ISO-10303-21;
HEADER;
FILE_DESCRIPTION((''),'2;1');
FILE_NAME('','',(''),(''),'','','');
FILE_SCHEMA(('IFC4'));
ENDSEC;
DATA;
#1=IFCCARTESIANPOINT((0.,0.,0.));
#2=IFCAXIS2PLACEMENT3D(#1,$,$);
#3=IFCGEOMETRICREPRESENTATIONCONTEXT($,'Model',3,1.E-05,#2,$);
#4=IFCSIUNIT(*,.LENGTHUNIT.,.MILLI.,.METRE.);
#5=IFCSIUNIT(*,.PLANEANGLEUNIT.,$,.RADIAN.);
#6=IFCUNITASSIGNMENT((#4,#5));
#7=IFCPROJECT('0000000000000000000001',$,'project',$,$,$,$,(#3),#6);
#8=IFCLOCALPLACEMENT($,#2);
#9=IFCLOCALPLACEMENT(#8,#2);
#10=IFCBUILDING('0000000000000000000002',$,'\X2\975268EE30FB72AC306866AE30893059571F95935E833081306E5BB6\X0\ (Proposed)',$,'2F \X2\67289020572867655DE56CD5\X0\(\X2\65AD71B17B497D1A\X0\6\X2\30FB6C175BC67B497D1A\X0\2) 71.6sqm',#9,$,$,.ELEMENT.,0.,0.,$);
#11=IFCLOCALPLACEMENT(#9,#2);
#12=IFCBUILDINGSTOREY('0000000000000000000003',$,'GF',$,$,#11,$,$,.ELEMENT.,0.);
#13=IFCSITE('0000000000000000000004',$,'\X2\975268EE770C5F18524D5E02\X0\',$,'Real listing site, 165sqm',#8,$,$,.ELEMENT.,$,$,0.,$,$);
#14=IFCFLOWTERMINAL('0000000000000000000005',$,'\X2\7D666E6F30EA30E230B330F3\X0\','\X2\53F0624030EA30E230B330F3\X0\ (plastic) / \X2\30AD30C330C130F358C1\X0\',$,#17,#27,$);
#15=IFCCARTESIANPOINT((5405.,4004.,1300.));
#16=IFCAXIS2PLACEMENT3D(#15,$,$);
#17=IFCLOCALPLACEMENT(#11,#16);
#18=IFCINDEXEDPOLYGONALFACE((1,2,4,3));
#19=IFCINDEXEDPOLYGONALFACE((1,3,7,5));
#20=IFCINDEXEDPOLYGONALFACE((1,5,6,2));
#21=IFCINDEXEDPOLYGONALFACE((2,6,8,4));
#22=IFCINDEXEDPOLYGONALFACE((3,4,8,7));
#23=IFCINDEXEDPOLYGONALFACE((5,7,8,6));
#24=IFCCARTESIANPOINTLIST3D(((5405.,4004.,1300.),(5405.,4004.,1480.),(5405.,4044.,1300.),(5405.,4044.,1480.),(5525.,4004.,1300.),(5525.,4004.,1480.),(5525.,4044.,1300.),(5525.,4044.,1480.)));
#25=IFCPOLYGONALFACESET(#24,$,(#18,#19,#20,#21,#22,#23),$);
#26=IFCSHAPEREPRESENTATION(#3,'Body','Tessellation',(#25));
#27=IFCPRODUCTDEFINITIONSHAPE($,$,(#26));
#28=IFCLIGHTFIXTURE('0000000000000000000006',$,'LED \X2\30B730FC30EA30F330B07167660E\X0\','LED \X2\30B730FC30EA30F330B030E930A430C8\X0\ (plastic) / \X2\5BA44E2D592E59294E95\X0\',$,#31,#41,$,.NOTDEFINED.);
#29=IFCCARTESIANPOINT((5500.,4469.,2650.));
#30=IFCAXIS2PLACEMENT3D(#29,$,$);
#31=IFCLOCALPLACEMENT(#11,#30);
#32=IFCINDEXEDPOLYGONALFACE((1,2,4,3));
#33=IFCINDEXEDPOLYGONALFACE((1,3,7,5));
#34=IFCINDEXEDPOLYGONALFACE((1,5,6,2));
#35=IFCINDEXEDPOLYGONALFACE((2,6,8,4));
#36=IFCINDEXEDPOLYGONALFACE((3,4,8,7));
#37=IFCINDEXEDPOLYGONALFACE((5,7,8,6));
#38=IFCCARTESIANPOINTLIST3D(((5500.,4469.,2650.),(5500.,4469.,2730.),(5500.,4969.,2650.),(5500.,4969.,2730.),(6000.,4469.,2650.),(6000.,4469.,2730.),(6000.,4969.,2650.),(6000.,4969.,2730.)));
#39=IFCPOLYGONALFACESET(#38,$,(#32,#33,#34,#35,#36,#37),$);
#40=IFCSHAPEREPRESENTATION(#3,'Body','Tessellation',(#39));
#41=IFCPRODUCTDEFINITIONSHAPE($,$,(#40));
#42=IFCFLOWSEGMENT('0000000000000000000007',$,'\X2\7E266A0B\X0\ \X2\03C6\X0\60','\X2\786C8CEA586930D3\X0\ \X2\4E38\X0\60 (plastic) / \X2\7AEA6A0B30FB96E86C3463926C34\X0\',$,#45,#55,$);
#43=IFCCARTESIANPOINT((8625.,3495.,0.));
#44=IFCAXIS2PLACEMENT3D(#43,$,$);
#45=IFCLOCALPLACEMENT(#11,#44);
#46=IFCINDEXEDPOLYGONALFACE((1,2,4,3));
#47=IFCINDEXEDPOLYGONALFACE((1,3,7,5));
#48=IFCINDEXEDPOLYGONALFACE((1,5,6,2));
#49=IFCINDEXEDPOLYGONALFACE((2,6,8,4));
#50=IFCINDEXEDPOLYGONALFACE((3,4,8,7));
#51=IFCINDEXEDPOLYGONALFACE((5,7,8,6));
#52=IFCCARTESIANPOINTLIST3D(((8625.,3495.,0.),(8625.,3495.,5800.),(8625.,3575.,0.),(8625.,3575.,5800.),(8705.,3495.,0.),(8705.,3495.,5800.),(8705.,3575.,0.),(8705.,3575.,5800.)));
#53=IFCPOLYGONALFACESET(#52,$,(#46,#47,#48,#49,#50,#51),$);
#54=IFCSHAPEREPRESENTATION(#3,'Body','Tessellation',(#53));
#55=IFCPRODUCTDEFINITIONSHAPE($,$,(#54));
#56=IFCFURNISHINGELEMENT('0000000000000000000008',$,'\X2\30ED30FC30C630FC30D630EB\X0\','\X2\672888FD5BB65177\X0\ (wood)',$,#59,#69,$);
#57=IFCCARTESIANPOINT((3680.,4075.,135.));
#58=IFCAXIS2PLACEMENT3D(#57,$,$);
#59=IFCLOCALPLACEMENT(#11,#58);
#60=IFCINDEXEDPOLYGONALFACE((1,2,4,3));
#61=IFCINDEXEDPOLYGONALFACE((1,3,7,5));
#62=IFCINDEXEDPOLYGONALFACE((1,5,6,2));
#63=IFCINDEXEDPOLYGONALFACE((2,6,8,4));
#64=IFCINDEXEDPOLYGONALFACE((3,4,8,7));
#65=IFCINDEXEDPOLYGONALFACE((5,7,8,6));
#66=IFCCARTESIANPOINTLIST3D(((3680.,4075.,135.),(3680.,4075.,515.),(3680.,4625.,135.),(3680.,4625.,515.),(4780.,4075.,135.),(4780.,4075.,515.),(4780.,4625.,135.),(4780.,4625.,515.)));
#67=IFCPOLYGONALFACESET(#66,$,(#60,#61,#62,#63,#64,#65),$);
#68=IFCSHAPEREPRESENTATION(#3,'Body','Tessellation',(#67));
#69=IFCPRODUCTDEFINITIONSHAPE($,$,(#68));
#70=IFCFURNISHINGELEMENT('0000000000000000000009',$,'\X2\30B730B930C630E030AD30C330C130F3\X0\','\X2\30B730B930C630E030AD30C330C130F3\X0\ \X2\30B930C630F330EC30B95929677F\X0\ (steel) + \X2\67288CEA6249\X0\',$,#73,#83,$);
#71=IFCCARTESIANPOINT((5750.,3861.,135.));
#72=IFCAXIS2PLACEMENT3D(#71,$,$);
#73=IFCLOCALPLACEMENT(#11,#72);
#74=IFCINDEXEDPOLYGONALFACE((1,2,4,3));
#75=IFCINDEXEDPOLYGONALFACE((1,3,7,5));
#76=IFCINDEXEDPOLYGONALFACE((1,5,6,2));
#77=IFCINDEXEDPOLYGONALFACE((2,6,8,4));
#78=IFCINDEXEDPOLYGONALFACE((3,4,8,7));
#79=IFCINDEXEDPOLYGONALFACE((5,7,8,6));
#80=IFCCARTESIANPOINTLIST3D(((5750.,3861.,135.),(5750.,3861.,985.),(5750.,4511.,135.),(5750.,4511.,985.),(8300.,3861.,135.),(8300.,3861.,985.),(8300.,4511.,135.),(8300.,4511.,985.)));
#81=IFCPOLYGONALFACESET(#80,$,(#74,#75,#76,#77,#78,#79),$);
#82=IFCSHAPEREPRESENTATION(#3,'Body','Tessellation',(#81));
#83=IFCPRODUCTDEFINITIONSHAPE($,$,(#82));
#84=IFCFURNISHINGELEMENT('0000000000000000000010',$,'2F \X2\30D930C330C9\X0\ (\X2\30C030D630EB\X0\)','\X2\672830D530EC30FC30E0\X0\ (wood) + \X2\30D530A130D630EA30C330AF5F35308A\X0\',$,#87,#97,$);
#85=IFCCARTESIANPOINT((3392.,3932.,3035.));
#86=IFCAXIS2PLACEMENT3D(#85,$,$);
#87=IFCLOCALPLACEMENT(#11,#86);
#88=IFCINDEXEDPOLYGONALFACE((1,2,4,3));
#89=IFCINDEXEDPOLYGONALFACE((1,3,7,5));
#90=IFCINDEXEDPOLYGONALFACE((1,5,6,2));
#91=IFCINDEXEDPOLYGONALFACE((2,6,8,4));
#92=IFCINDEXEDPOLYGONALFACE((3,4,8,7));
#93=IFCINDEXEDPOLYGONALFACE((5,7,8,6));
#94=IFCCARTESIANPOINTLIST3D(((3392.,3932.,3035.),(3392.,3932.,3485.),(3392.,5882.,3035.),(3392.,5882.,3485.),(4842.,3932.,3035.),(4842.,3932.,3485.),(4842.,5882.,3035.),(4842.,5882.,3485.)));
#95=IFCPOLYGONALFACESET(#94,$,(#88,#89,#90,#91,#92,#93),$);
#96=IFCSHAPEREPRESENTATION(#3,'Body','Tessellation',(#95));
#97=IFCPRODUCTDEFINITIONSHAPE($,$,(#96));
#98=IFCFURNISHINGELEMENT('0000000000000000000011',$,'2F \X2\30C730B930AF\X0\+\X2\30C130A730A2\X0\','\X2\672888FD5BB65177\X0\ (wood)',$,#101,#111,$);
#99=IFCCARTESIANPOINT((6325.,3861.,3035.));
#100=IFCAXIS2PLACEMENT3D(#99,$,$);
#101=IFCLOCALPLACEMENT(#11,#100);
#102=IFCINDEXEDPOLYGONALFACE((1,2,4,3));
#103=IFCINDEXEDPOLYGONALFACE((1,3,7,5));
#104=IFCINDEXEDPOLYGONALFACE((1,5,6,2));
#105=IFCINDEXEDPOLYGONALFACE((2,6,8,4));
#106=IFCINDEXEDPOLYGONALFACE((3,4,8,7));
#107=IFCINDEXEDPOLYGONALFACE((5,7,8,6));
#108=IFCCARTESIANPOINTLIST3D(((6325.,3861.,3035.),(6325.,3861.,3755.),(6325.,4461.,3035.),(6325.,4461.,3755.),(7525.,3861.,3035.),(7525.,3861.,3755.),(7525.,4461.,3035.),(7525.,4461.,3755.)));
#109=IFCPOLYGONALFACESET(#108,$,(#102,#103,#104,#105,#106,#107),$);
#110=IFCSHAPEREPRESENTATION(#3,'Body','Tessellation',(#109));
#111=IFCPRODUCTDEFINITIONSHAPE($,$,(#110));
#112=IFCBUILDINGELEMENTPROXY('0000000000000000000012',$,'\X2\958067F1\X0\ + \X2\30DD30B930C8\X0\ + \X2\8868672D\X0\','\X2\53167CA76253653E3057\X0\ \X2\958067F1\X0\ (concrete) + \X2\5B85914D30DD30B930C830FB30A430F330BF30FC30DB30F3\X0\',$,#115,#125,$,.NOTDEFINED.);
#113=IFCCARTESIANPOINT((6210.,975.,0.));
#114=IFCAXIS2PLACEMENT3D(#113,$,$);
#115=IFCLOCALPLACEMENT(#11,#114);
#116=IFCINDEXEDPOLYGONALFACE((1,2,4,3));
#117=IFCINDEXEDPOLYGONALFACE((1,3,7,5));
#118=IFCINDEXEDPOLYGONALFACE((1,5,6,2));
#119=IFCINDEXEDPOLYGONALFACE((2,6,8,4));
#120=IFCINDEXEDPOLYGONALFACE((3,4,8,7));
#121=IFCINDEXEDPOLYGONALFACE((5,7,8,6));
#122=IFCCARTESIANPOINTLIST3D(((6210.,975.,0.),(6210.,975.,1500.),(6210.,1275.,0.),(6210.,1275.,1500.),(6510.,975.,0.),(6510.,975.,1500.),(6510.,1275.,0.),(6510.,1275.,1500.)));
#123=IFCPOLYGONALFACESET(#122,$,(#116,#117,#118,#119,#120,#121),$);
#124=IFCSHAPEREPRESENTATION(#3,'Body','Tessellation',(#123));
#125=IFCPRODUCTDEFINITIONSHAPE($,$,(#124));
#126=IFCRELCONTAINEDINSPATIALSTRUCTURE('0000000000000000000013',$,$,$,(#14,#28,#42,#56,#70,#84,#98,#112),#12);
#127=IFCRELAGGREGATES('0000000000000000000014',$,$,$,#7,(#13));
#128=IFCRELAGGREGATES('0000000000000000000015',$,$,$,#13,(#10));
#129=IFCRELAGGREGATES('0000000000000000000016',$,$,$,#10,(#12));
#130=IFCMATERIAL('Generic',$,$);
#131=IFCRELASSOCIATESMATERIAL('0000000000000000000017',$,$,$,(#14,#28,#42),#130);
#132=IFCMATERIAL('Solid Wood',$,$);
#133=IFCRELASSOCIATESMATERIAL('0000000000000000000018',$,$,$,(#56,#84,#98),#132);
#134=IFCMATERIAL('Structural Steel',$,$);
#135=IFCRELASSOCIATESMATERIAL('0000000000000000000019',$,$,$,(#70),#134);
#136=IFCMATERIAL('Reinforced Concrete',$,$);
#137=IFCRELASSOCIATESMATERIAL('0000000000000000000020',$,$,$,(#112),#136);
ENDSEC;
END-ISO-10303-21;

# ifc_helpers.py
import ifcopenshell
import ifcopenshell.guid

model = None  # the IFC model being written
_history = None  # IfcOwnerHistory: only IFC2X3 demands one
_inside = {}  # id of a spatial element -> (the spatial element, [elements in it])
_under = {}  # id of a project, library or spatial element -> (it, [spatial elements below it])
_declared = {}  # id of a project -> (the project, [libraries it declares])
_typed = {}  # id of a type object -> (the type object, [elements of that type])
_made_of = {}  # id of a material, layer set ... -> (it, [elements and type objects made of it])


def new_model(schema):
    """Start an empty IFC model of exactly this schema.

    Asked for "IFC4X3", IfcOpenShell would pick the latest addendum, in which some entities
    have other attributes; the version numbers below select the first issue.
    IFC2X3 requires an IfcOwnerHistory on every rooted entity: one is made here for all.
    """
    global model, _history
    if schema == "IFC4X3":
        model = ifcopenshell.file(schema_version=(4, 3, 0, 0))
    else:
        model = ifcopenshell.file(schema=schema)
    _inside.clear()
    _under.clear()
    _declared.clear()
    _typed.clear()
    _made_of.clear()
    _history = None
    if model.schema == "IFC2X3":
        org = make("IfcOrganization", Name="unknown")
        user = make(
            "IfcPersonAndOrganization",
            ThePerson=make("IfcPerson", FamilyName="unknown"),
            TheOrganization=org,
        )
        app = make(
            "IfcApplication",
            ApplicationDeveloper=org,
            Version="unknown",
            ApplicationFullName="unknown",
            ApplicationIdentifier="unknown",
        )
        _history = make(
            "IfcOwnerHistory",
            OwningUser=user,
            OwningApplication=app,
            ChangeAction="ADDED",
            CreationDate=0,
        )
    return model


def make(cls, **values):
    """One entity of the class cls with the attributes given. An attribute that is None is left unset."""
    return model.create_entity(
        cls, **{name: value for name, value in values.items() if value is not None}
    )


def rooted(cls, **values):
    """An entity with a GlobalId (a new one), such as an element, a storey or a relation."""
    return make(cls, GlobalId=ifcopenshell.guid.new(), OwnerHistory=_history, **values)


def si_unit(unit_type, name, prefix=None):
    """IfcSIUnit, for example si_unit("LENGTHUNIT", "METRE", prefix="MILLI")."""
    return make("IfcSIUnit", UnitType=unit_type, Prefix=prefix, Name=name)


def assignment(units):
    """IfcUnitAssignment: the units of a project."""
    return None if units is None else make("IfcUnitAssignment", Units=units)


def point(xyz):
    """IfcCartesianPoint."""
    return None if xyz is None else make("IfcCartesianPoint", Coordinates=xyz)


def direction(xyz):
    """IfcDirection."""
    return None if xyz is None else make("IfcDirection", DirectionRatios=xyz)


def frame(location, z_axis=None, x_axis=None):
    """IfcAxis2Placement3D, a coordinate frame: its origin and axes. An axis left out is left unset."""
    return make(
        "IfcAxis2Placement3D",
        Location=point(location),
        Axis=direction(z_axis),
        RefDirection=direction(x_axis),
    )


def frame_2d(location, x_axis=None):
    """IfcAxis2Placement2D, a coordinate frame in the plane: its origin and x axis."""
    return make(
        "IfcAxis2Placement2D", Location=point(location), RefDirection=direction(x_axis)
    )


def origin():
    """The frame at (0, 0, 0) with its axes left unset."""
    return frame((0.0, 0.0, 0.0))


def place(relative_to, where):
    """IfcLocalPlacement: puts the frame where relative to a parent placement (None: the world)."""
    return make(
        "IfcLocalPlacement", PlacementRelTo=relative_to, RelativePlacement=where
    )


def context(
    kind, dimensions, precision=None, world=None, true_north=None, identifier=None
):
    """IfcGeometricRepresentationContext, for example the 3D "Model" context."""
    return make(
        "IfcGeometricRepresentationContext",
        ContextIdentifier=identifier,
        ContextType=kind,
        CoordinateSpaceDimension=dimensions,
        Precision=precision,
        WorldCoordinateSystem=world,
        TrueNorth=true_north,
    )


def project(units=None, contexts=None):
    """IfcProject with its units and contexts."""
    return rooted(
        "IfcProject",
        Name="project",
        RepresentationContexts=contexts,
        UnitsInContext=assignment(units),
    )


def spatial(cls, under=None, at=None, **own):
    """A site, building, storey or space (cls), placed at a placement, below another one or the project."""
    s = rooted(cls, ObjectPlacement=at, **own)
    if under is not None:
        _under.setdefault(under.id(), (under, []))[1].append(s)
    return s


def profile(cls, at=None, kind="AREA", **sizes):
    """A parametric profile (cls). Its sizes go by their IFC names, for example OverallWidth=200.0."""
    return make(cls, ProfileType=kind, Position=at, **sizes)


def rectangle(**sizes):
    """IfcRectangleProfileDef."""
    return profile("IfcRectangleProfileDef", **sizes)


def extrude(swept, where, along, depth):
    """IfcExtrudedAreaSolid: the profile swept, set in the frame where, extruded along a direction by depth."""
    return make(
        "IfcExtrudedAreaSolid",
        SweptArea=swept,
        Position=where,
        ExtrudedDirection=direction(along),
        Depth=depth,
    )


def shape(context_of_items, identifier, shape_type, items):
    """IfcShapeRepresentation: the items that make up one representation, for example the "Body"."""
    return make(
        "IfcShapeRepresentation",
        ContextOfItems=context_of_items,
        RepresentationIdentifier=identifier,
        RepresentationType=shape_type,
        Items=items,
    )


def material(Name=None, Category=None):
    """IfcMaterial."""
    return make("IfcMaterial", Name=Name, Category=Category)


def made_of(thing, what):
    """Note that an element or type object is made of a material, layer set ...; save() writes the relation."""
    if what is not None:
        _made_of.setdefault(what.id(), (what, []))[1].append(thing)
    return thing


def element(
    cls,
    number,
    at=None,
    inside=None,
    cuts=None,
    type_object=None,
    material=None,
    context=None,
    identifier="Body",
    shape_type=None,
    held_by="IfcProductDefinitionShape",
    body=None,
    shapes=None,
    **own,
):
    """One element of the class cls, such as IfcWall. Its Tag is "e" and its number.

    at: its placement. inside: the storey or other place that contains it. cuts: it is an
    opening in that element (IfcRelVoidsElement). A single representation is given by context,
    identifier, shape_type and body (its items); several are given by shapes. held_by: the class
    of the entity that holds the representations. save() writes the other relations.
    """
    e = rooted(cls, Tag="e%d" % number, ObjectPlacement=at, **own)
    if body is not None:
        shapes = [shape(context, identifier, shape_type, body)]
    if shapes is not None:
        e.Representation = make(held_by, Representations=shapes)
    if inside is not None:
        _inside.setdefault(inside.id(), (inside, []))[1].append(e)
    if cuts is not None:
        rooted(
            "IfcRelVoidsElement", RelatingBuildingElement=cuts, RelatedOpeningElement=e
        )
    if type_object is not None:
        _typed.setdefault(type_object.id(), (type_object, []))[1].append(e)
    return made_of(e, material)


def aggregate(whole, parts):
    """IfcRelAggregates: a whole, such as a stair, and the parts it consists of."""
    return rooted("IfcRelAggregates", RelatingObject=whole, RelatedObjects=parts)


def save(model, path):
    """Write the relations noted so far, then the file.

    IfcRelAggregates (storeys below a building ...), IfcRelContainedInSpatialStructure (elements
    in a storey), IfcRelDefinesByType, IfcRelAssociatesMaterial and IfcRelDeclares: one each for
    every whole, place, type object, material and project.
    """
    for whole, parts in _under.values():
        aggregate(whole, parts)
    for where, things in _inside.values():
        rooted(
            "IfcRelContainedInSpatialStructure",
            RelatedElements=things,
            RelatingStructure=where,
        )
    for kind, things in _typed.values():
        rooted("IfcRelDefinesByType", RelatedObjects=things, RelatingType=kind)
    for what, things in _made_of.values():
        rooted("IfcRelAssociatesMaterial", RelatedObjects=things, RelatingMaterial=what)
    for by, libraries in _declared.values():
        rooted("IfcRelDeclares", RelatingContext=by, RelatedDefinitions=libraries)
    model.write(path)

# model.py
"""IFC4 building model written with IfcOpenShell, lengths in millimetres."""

from ifc_helpers import new_model, si_unit, frame, frame_2d, origin, place, context, project, spatial, rectangle, extrude, material, element, save


model = new_model("IFC4")

# Units and contexts
model_context = context("Model", 3, precision=1e-05, world=origin())
ifc_project = project(units=[si_unit("LENGTHUNIT", "METRE", prefix="MILLI"), si_unit("PLANEANGLEUNIT", "RADIAN")], contexts=[model_context])

# Site, building, storey
site_placement = place(None, origin())
site = spatial("IfcSite", under=ifc_project, at=site_placement, Name="青森県弘前市", ObjectType="Real listing site, 165sqm", CompositionType="ELEMENT", RefElevation=0.0)
building_placement = place(site_placement, origin())
building = spatial("IfcBuilding", under=site, at=building_placement, Name="青森・犬と暮らす土間広めの家 (Proposed)", ObjectType="2F 木造在来工法(断熱等級6・気密等級2) 71.6sqm", CompositionType="ELEMENT", ElevationOfRefHeight=0.0, ElevationOfTerrain=0.0)
storey_placement = place(building_placement, origin())
storey = spatial("IfcBuildingStorey", under=building, at=storey_placement, Name="GF", CompositionType="ELEMENT", Elevation=0.0)

# Shared definitions
ifc_material_1 = material(Name="Solid Wood")

# Shared definitions
ifc_material_2 = material(Name="Reinforced Concrete")

# Shared definitions
ifc_material_3 = material(Name="Structural Steel")

# Flow terminal
ifc_material_4 = material(Name="Generic")
flow_terminal_1_placement = place(storey_placement, frame((5405.0, 4004.0, 1300.0)))
element("IfcFlowTerminal", 1, at=flow_terminal_1_placement, inside=storey, material=ifc_material_4, Name="給湯リモコン", Description="台所リモコン (plastic) / キッチン壁", context=model_context, shape_type="SweptSolid", body=[
    extrude(rectangle(XDim=120.0, YDim=40.0, at=frame_2d((60.0, 20.0))), frame((5405.0, 4004.0, 1300.0)), (0.0, 0.0, 1.0), 180.0),
])

# Light fixture
light_fixture_placement = place(storey_placement, frame((5500.0, 4469.0, 2650.0)))
element("IfcLightFixture", 2, at=light_fixture_placement, inside=storey, material=ifc_material_4, Name="LED シーリング照明", Description="LED シーリングライト (plastic) / 室中央天井", PredefinedType="NOTDEFINED", context=model_context, shape_type="SweptSolid", body=[
    extrude(rectangle(XDim=500.0, YDim=500.0, at=frame_2d((250.0, 250.0))), frame((5500.0, 4469.0, 2650.0)), (0.0, 0.0, 1.0), 80.0),
])

# Flow segment
flow_segment_placement = place(storey_placement, frame((8625.0, 3495.0, 0.0)))
element("IfcFlowSegment", 3, at=flow_segment_placement, inside=storey, material=ifc_material_4, Name="縦樋 φ60", Description="硬質塩ビ 丸60 (plastic) / 竪樋・雨水排水", context=model_context, shape_type="SweptSolid", body=[
    extrude(rectangle(XDim=80.0, YDim=80.0, at=frame_2d((40.0, 40.0))), frame((8625.0, 3495.0, 0.0)), (0.0, 0.0, 1.0), 5800.0),
])

# Furnishing elements
furnishing_1_placement = place(storey_placement, frame((3680.0, 4075.0, 135.0)))
element("IfcFurnishingElement", 4, at=furnishing_1_placement, inside=storey, material=ifc_material_1, Name="ローテーブル", Description="木製家具 (wood)", context=model_context, shape_type="SweptSolid", body=[
    extrude(rectangle(XDim=1100.0, YDim=550.0, at=frame_2d((550.0, 275.0))), frame((3680.0, 4075.0, 135.0)), (0.0, 0.0, 1.0), 380.0),
])
furnishing_2_placement = place(storey_placement, frame((5750.0, 3861.0, 135.0)))
element("IfcFurnishingElement", 5, at=furnishing_2_placement, inside=storey, material=ifc_material_3, Name="システムキッチン", Description="システムキッチン ステンレス天板 (steel) + 木質扉", context=model_context, shape_type="SweptSolid", body=[
    extrude(rectangle(XDim=2550.0, YDim=650.0, at=frame_2d((1275.0, 325.0))), frame((5750.0, 3861.0, 135.0)), (0.0, 0.0, 1.0), 850.0),
])
furnishing_3_placement = place(storey_placement, frame((3392.0, 3932.0, 3035.0)))
element("IfcFurnishingElement", 6, at=furnishing_3_placement, inside=storey, material=ifc_material_1, Name="2F ベッド (ダブル)", Description="木フレーム (wood) + ファブリック張り", context=model_context, shape_type="SweptSolid", body=[
    extrude(rectangle(XDim=1450.0, YDim=1950.0, at=frame_2d((725.0, 975.0))), frame((3392.0, 3932.0, 3035.0)), (0.0, 0.0, 1.0), 450.0),
])
furnishing_4_placement = place(storey_placement, frame((6325.0, 3861.0, 3035.0)))
element("IfcFurnishingElement", 7, at=furnishing_4_placement, inside=storey, material=ifc_material_1, Name="2F デスク+チェア", Description="木製家具 (wood)", context=model_context, shape_type="SweptSolid", body=[
    extrude(rectangle(XDim=1200.0, YDim=600.0, at=frame_2d((600.0, 300.0))), frame((6325.0, 3861.0, 3035.0)), (0.0, 0.0, 1.0), 720.0),
])

# Building element proxy
proxy_placement = place(storey_placement, frame((6210.0, 975.0, 0.0)))
element("IfcBuildingElementProxy", 8, at=proxy_placement, inside=storey, material=ifc_material_2, Name="門柱 + ポスト + 表札", Description="化粧打放し 門柱 (concrete) + 宅配ポスト・インターホン", PredefinedType="NOTDEFINED", context=model_context, shape_type="SweptSolid", body=[
    extrude(rectangle(XDim=300.0, YDim=300.0, at=frame_2d((150.0, 150.0))), frame((6210.0, 975.0, 0.0)), (0.0, 0.0, 1.0), 1500.0),
])

save(model, "model.ifc")
